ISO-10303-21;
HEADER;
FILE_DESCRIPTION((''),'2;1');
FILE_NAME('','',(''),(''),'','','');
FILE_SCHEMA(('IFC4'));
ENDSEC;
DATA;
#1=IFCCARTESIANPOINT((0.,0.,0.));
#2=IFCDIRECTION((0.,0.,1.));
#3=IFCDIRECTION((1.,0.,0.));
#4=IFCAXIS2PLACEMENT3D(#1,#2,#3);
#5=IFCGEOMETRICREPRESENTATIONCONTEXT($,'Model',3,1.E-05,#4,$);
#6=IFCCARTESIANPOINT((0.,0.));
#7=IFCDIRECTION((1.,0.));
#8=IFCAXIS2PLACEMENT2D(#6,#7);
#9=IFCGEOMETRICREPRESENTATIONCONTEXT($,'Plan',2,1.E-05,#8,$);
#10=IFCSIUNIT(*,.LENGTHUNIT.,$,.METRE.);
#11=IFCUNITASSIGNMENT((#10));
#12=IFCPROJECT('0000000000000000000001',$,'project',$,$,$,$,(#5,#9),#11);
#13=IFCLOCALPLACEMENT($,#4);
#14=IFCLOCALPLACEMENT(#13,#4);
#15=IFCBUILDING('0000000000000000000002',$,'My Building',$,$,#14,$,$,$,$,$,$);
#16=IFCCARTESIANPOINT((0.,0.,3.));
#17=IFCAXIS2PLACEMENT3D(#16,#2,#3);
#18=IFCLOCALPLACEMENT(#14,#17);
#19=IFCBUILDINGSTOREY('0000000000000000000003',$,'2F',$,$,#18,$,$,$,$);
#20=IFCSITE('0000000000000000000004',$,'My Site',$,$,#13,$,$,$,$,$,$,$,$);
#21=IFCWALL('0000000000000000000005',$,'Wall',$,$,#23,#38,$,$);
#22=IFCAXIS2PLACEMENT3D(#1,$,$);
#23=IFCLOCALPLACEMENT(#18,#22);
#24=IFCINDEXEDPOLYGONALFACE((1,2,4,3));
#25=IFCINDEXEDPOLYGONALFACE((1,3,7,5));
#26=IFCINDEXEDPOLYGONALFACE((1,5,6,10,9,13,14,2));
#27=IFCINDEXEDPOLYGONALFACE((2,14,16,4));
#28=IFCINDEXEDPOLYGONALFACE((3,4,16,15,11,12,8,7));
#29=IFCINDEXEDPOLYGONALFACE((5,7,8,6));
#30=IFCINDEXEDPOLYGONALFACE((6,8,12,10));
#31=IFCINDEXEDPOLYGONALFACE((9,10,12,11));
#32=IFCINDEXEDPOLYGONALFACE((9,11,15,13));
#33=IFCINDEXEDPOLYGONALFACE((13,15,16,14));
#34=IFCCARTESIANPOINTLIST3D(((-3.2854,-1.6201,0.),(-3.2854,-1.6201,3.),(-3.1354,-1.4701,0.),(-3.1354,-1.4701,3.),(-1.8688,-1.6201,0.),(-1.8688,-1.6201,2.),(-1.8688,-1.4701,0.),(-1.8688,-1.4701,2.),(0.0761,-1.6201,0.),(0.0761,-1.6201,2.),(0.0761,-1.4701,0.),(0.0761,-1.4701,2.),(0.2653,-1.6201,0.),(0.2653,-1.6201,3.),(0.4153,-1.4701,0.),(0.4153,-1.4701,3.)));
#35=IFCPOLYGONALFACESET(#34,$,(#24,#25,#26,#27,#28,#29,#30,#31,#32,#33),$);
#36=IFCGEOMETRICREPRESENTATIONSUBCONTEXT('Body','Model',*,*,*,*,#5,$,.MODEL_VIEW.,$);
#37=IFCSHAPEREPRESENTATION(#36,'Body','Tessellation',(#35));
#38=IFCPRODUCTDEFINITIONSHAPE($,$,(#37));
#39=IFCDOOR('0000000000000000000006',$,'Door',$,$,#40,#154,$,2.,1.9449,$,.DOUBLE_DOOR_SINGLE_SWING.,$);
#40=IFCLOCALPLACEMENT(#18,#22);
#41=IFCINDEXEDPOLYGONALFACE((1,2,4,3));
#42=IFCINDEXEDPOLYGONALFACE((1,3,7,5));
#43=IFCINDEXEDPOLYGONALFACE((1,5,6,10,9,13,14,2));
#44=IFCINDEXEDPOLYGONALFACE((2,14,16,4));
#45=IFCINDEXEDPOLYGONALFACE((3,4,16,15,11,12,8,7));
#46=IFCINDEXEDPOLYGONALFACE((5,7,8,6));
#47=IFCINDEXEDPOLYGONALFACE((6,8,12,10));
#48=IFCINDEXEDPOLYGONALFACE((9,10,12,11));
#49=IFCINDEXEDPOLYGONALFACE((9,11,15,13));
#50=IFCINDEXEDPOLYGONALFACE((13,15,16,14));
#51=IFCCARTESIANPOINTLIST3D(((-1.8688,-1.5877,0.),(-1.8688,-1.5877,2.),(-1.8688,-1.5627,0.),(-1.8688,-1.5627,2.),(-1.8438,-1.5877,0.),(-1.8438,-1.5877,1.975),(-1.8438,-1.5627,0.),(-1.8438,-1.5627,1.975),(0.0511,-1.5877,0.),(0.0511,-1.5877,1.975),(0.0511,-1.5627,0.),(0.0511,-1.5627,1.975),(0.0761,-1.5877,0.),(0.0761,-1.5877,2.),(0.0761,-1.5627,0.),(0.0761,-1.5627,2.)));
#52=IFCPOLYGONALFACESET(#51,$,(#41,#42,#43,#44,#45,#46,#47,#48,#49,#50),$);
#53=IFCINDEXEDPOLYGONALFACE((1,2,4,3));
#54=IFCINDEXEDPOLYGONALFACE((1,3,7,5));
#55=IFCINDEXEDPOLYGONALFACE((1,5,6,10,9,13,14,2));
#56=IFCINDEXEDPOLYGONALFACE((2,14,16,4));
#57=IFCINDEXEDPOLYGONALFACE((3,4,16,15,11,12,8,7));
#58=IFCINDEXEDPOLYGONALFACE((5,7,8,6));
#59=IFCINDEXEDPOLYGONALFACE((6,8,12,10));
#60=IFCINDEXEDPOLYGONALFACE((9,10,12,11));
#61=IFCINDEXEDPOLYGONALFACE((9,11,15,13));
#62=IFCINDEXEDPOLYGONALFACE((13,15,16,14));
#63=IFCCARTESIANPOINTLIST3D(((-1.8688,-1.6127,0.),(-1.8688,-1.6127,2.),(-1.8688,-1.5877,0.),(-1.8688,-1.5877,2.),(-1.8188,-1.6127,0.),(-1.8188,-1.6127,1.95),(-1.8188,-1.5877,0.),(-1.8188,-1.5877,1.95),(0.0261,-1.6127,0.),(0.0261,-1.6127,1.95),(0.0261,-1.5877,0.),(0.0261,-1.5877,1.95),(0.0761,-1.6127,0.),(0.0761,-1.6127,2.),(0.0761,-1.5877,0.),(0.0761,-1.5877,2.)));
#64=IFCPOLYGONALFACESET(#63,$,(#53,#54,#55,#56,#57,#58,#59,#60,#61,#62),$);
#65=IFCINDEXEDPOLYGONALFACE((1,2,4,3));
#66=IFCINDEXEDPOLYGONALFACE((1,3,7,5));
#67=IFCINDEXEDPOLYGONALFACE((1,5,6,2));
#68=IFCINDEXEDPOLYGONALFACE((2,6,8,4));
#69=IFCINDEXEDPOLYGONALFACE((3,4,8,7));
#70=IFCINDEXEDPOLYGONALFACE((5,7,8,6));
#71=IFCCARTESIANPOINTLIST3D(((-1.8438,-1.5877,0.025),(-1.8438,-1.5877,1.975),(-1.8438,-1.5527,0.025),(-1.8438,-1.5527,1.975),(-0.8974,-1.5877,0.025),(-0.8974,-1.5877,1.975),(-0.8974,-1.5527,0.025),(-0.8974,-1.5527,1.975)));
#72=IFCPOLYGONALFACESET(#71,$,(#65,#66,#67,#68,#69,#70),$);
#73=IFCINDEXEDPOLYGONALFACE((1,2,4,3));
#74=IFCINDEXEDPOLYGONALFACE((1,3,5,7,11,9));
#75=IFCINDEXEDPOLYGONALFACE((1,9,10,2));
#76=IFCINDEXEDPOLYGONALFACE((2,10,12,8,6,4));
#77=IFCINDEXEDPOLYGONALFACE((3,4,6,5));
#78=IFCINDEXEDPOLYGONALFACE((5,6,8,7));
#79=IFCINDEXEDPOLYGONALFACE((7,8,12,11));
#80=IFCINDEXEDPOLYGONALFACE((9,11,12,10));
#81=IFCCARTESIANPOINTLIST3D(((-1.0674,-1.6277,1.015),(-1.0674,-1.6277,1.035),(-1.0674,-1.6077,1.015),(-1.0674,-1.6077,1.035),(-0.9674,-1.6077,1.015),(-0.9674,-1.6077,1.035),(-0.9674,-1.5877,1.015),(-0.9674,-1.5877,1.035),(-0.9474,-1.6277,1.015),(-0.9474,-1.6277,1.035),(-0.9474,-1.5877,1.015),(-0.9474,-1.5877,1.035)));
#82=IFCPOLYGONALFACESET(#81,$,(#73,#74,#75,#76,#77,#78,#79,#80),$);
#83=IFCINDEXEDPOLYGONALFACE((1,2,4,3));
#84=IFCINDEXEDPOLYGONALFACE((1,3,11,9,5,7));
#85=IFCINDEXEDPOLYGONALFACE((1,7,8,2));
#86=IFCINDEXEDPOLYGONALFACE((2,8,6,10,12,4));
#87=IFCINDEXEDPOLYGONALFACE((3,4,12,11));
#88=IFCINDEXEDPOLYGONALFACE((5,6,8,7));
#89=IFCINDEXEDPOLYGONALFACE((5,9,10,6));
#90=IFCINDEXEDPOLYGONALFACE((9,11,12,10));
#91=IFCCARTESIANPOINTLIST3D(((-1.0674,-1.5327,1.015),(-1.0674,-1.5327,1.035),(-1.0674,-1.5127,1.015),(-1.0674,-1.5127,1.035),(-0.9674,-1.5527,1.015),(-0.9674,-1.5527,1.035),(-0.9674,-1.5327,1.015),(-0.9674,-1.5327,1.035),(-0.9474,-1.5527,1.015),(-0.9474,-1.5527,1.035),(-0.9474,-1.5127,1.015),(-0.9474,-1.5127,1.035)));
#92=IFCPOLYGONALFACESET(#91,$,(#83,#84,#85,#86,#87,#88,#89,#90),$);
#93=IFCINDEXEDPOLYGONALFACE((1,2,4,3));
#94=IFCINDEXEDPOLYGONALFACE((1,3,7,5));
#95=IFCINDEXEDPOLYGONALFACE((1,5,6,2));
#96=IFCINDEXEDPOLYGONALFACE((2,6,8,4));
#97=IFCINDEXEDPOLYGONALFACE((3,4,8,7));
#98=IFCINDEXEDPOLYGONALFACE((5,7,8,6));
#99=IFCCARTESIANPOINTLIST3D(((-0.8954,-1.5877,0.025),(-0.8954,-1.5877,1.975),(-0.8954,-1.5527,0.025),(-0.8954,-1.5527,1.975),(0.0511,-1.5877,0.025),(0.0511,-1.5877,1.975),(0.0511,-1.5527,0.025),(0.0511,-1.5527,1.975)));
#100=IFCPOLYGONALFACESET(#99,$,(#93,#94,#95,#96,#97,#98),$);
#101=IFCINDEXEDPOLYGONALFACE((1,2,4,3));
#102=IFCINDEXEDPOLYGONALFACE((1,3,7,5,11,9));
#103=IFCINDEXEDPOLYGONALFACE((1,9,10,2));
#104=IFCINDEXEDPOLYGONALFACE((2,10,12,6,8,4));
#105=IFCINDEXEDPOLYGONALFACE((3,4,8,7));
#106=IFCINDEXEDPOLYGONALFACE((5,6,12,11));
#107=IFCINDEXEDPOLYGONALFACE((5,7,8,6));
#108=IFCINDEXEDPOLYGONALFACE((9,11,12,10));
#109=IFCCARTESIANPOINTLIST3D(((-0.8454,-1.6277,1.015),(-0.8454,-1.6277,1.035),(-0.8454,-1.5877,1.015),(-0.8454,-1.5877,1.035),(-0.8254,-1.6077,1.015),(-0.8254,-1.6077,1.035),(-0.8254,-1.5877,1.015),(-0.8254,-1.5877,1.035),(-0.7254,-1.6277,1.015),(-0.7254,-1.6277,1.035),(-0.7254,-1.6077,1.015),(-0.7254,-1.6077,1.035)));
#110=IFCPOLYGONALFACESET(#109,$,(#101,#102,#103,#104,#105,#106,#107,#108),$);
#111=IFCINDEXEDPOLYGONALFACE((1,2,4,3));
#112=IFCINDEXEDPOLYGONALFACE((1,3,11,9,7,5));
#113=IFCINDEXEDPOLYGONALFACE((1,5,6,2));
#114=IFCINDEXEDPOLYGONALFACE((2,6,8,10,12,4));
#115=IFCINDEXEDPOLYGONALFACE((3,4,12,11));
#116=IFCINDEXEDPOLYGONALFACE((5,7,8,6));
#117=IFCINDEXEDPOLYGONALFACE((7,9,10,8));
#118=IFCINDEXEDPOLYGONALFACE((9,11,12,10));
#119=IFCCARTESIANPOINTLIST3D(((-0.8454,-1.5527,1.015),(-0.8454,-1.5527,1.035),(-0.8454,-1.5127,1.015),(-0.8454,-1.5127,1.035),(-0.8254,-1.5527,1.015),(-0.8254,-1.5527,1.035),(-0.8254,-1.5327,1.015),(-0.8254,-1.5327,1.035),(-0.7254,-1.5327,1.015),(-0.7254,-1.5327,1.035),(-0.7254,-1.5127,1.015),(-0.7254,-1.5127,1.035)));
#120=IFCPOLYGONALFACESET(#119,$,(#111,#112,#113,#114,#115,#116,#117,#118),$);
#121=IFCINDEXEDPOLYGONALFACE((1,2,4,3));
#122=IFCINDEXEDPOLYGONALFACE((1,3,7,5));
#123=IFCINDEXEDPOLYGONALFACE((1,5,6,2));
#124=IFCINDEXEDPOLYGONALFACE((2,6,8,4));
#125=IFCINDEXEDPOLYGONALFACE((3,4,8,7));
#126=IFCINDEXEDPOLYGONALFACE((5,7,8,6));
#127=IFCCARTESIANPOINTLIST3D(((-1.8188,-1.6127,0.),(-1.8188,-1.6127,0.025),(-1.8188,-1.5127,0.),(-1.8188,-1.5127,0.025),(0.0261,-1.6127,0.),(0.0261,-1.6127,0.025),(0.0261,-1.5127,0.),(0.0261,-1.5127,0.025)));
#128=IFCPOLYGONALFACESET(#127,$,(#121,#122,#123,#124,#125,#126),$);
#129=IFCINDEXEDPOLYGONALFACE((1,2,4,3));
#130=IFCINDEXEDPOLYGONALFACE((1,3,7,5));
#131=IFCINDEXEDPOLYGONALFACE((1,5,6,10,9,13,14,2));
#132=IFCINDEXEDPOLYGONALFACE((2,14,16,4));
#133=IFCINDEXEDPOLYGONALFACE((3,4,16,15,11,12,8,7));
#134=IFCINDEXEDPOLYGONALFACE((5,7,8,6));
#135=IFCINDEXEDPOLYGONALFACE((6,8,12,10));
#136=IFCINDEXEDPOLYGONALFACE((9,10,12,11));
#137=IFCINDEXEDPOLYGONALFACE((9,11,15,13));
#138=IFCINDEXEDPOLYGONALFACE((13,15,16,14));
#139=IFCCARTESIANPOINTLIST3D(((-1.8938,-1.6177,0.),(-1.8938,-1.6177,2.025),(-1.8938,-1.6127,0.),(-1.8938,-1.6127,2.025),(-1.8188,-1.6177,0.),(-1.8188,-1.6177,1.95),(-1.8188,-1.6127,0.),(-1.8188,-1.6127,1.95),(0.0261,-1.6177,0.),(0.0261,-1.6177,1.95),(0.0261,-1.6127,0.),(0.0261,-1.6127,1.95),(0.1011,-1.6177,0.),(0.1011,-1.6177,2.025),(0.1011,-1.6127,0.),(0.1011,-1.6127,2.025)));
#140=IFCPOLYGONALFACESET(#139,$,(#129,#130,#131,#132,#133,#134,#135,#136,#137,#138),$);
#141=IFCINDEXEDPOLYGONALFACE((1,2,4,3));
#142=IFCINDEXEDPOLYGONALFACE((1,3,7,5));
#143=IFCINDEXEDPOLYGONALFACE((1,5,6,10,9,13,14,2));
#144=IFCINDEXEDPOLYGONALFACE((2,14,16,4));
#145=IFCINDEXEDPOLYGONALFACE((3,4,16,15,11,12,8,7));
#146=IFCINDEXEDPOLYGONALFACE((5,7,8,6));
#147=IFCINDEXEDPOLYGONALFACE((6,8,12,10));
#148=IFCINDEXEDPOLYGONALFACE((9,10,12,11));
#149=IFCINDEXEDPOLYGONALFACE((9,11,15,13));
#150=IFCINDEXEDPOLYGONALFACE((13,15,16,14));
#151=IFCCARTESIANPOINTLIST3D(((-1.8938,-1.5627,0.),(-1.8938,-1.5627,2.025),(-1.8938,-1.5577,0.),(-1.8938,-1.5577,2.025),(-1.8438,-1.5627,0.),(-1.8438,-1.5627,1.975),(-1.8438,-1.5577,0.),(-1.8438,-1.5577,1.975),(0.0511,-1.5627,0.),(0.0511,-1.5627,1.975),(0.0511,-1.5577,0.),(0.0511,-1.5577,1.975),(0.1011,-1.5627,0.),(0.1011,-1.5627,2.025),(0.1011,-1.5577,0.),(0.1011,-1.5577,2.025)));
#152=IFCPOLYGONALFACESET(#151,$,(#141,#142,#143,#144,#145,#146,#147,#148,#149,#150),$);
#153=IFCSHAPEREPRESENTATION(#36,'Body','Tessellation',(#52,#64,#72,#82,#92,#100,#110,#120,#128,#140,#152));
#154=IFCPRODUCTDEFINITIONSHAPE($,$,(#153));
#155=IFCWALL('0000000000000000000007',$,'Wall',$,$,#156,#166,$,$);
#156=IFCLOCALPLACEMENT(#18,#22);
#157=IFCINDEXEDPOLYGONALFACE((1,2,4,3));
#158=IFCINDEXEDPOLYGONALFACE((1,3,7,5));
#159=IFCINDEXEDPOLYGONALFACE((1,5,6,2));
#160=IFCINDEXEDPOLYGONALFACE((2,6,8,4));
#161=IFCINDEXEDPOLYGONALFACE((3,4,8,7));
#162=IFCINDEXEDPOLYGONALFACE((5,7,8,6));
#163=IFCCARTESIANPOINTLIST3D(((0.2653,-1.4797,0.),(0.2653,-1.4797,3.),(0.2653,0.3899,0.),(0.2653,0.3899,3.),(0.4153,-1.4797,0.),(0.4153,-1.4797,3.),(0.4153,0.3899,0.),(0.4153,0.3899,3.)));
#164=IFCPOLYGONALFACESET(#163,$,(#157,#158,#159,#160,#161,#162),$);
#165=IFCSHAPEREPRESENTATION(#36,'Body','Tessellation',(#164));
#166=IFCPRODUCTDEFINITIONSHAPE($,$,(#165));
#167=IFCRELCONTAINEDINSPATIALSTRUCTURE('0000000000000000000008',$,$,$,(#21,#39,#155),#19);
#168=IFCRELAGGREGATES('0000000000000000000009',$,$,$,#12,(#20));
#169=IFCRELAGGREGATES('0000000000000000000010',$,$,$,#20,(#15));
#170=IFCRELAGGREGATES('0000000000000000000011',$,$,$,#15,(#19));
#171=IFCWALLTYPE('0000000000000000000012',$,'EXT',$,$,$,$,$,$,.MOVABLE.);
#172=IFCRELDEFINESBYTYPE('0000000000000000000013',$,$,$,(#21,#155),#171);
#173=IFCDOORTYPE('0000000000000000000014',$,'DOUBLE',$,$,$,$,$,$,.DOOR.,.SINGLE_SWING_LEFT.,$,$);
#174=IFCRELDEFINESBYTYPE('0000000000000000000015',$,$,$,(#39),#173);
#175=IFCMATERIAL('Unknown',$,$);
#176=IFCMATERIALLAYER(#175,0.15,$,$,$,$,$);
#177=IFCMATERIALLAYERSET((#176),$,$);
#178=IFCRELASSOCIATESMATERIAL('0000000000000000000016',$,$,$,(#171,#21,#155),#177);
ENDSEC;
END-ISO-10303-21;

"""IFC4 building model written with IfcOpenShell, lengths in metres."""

from ifc_helpers import new_model, entity, si_unit, frame, origin_with_axes, origin_2d_with_axis, place, context, subcontext, project, spatial, line, indexed_curve, outline, extrude, shape, source, transform, mapped, material, layer, layer_set, layer_usage, type_object, type_shapes, element, fill, save


model = new_model("IFC4")

# Units and contexts
model_context = context("Model", 3, precision=1e-05, world=origin_with_axes())
plan_context = context("Plan", 2, precision=1e-05, world=origin_2d_with_axis())
body_context_1 = subcontext(model_context, "Body", "Model", "MODEL_VIEW")
body_context_2 = subcontext(plan_context, "Body", "Plan", "PLAN_VIEW")
ifc_project = project(units=[si_unit("LENGTHUNIT", "METRE")], contexts=[model_context, plan_context])

# Site, building, storey
site_placement = place(None, origin_with_axes())
site = spatial("IfcSite", under=ifc_project, at=site_placement, Name="My Site")
building_placement = place(site_placement, origin_with_axes())
building = spatial("IfcBuilding", under=site, at=building_placement, Name="My Building")
storey_placement = place(building_placement, frame((0.0, 0.0, 3.0), z_axis=(0.0, 0.0, 1.0), x_axis=(1.0, 0.0, 0.0)))
storey = spatial("IfcBuildingStorey", under=building, at=storey_placement, Name="2F")

# Shared definitions
ifc_material = material(Name="Unknown")

# Shared definitions
ifc_layer_1 = layer(ifc_material, 0.15)
ifc_layer_set_1 = layer_set([ifc_layer_1])
wall_type = type_object("IfcWallType", Name="EXT", PredefinedType="MOVABLE", material=ifc_layer_set_1)

# Wall, opening, door
ifc_layer_usage_1 = layer_usage(ifc_layer_set_1, "AXIS2", "POSITIVE", -0.15)
wall_1_placement = place(storey_placement, frame((0.2653, -1.6201, 0.0), z_axis=(0.0, 0.0, 1.0), x_axis=(-1.0, 0.0, 0.0)))
wall_1 = element("IfcWall", 1, at=wall_1_placement, inside=storey, type_object=wall_type, material=ifc_layer_usage_1, Name="Wall", context=body_context_1, shape_type="SweptSolid", body=[
    extrude(outline(indexed_curve([(-0.15, -0.15), (0.0, 0.0), (3.5507, 0.0), (3.4007, -0.15)], segments=[line(1, 2, 3, 4, 1)])), origin_with_axes(), (0.0, 0.0, 1.0), 3.0),
])
placement_1 = place(storey_placement, frame((-1.8688, -1.6127, 0.0), z_axis=(0.0, 0.0, 1.0), x_axis=(1.0, 0.0, 0.0)))
opening_1 = element("IfcOpeningElement", 2, at=placement_1, cuts=wall_1, PredefinedType="OPENING", context=body_context_1, shape_type="SweptSolid", body=[
    extrude(outline(indexed_curve([(0.0, 0.0), (1.9449, 0.0), (1.9449, 2.0), (0.0, 2.0)], segments=[line(1, 2, 3, 4, 1)])), frame((0.0, -0.6, 0.0), z_axis=(0.0, -1.0, 0.0), x_axis=(1.0, 0.0, 0.0)), (0.0, 0.0, -1.0), 1.2),
])
door_type_1 = type_object("IfcDoorType", Name="DOUBLE", OperationType="SINGLE_SWING_LEFT", PredefinedType="DOOR")
shared_shape_1 = source(origin_with_axes(), body_context_1, "Body", "SweptSolid", [
    extrude(outline(indexed_curve([(0.0, 0.0), (0.0, 2.0), (1.9449, 2.0), (1.9449, 0.0), (1.9199, 0.0), (1.9199, 1.975), (0.025, 1.975), (0.025, 0.0)], segments=[line(1, 2, 3, 4, 5, 6, 7, 8, 1)])), frame((0.0, 0.025, 0.0), z_axis=(0.0, -1.0, 0.0), x_axis=(1.0, 0.0, 0.0)), (0.0, 0.0, -1.0), 0.025),
    extrude(outline(indexed_curve([(0.0, 0.0), (0.0, 2.0), (1.9449, 2.0), (1.9449, 0.0), (1.8949, 0.0), (1.8949, 1.95), (0.05, 1.95), (0.05, 0.0)], segments=[line(1, 2, 3, 4, 5, 6, 7, 8, 1)])), frame((0.0, 0.0, 0.0), z_axis=(0.0, -1.0, 0.0), x_axis=(1.0, 0.0, 0.0)), (0.0, 0.0, -1.0), 0.025),
    extrude(outline(indexed_curve([(0.0, 0.0), (0.9465, 0.0), (0.9465, 0.035), (0.0, 0.035)], segments=[line(1, 2, 3, 4, 1)])), frame((0.025, 0.025, 0.025), z_axis=(0.0, 0.0, 1.0), x_axis=(1.0, 0.0, 0.0)), (0.0, 0.0, 1.0), 1.95),
    extrude(outline(indexed_curve([(0.0, 0.0), (0.0, -0.04), (-0.12, -0.04), (-0.12, -0.02), (-0.02, -0.02), (-0.02, 0.0)], segments=[line(1, 2, 3, 4, 5, 6, 1)])), frame((0.9215, 0.025, 1.015), z_axis=(0.0, 0.0, 1.0), x_axis=(1.0, 0.0, 0.0)), (0.0, 0.0, 1.0), 0.02),
    extrude(outline(indexed_curve([(0.0, 0.0), (0.0, 0.04), (-0.12, 0.04), (-0.12, 0.02), (-0.02, 0.02), (-0.02, 0.0)], segments=[line(1, 2, 3, 4, 5, 6, 1)])), frame((0.9215, 0.06, 1.015), z_axis=(0.0, 0.0, 1.0), x_axis=(1.0, 0.0, 0.0)), (0.0, 0.0, 1.0), 0.02),
    extrude(outline(indexed_curve([(0.0, 0.0), (-0.9465, 0.0), (-0.9465, 0.035), (0.0, 0.035)], segments=[line(1, 2, 3, 4, 1)])), frame((1.9199, 0.025, 0.025), z_axis=(0.0, 0.0, 1.0), x_axis=(1.0, 0.0, 0.0)), (0.0, 0.0, 1.0), 1.95),
    extrude(outline(indexed_curve([(0.0, 0.0), (0.0, -0.04), (0.12, -0.04), (0.12, -0.02), (0.02, -0.02), (0.02, 0.0)], segments=[line(1, 2, 3, 4, 5, 6, 1)])), frame((1.0235, 0.025, 1.015), z_axis=(0.0, 0.0, 1.0), x_axis=(1.0, 0.0, 0.0)), (0.0, 0.0, 1.0), 0.02),
    extrude(outline(indexed_curve([(0.0, 0.0), (0.0, 0.04), (0.12, 0.04), (0.12, 0.02), (0.02, 0.02), (0.02, 0.0)], segments=[line(1, 2, 3, 4, 5, 6, 1)])), frame((1.0235, 0.06, 1.015), z_axis=(0.0, 0.0, 1.0), x_axis=(1.0, 0.0, 0.0)), (0.0, 0.0, 1.0), 0.02),
    extrude(outline(indexed_curve([(0.0, 0.0), (1.8449, 0.0), (1.8449, 0.1), (0.0, 0.1)], segments=[line(1, 2, 3, 4, 1)])), frame((0.05, 0.0, 0.0), z_axis=(0.0, 0.0, 1.0), x_axis=(1.0, 0.0, 0.0)), (0.0, 0.0, 1.0), 0.025),
    extrude(outline(indexed_curve([(0.0, 0.0), (0.0, 2.025), (1.9949, 2.025), (1.9949, 0.0), (1.9199, 0.0), (1.9199, 1.95), (0.075, 1.95), (0.075, 0.0)], segments=[line(1, 2, 3, 4, 5, 6, 7, 8, 1)])), frame((-0.025, -0.005, 0.0), z_axis=(0.0, -1.0, 0.0), x_axis=(1.0, 0.0, 0.0)), (0.0, 0.0, -1.0), 0.005),
    extrude(outline(indexed_curve([(0.0, 0.0), (0.0, 2.025), (1.9949, 2.025), (1.9949, 0.0), (1.9449, 0.0), (1.9449, 1.975), (0.05, 1.975), (0.05, 0.0)], segments=[line(1, 2, 3, 4, 5, 6, 7, 8, 1)])), frame((-0.025, 0.05, 0.0), z_axis=(0.0, -1.0, 0.0), x_axis=(1.0, 0.0, 0.0)), (0.0, 0.0, -1.0), 0.005),
])
shared_shape_2 = source(origin_with_axes(), body_context_2, "Body", "Curve2D", [
    entity("IfcIndexedPolyCurve", entity("IfcCartesianPointList2D", [[0.0, 0.0], [0.0, 0.05], [0.025, 0.05], [0.025, 0.025], [0.05, 0.025], [0.05, 0.0]]), [entity("IfcLineIndex", [1, 2, 3, 4, 5, 6, 1])]),
    entity("IfcIndexedPolyCurve", entity("IfcCartesianPointList2D", [[1.9449, 0.0], [1.9449, 0.05], [1.9199, 0.05], [1.9199, 0.025], [1.8949, 0.025], [1.8949, 0.0]]), [entity("IfcLineIndex", [1, 2, 3, 4, 5, 6, 1])]),
    entity("IfcTrimmedCurve", entity("IfcEllipse", entity("IfcAxis2Placement2D", entity("IfcCartesianPoint", [0.06, 0.05]), entity("IfcDirection", [1.0, 0.0])), 0.9125, 0.9475), [entity("IfcCartesianPoint", [0.9725, 0.05])], [entity("IfcCartesianPoint", [0.06, 0.9975])], True, "CARTESIAN"),
    entity("IfcIndexedPolyCurve", entity("IfcCartesianPointList2D", [[0.025, 0.05], [0.06, 0.05], [0.06, 0.9975], [0.025, 0.9975]]), [entity("IfcLineIndex", [1, 2, 3, 4, 1])]),
    entity("IfcTrimmedCurve", entity("IfcEllipse", entity("IfcAxis2Placement2D", entity("IfcCartesianPoint", [1.8849, 0.05]), entity("IfcDirection", [1.0, 0.0])), 0.9125, 0.9475), [entity("IfcCartesianPoint", [1.8849, 0.9975])], [entity("IfcCartesianPoint", [0.9725, 0.05])], True, "CARTESIAN"),
    entity("IfcIndexedPolyCurve", entity("IfcCartesianPointList2D", [[1.9199, 0.05], [1.8849, 0.05], [1.8849, 0.9975], [1.9199, 0.9975]]), [entity("IfcLineIndex", [1, 2, 3, 4, 1])]),
])
type_shapes(door_type_1, [shared_shape_1, shared_shape_2])
door_1 = element("IfcDoor", 3, at=placement_1, inside=storey, type_object=door_type_1, Name="Door", OperationType="DOUBLE_DOOR_SINGLE_SWING", OverallHeight=2.0, OverallWidth=1.9449, shapes=[
    shape(body_context_1, "Body", "MappedRepresentation", [mapped(shared_shape_1, transform((0.0, 0.0, 0.0), x_axis=(1.0, 0.0, 0.0), y_axis=(0.0, 1.0, 0.0), z_axis=(0.0, 0.0, 1.0), scale=1.0))]),
    shape(body_context_2, "Body", "MappedRepresentation", [mapped(shared_shape_2, transform((0.0, 0.0, 0.0), x_axis=(1.0, 0.0, 0.0), y_axis=(0.0, 1.0, 0.0), z_axis=(0.0, 0.0, 1.0), scale=1.0))]),
])
fill(opening_1, door_1)

# Wall
ifc_layer_usage_2 = layer_usage(ifc_layer_set_1, "AXIS2", "POSITIVE", 0.0)
wall_2_placement = place(storey_placement, frame((0.2653, 0.3899, 0.0), z_axis=(0.0, 0.0, 1.0), x_axis=(0.0, -1.0, 0.0)))
element("IfcWall", 4, at=wall_2_placement, inside=storey, type_object=wall_type, material=ifc_layer_usage_2, Name="Wall", context=body_context_1, shape_type="SweptSolid", body=[
    extrude(outline(indexed_curve([(0.0, 0.0), (0.0, 0.15), (1.8696, 0.15), (1.8696, 0.0)], segments=[line(1, 2, 3, 4, 1)])), origin_with_axes(), (0.0, 0.0, 1.0), 3.0),
])

save(model, "model.ifc")
